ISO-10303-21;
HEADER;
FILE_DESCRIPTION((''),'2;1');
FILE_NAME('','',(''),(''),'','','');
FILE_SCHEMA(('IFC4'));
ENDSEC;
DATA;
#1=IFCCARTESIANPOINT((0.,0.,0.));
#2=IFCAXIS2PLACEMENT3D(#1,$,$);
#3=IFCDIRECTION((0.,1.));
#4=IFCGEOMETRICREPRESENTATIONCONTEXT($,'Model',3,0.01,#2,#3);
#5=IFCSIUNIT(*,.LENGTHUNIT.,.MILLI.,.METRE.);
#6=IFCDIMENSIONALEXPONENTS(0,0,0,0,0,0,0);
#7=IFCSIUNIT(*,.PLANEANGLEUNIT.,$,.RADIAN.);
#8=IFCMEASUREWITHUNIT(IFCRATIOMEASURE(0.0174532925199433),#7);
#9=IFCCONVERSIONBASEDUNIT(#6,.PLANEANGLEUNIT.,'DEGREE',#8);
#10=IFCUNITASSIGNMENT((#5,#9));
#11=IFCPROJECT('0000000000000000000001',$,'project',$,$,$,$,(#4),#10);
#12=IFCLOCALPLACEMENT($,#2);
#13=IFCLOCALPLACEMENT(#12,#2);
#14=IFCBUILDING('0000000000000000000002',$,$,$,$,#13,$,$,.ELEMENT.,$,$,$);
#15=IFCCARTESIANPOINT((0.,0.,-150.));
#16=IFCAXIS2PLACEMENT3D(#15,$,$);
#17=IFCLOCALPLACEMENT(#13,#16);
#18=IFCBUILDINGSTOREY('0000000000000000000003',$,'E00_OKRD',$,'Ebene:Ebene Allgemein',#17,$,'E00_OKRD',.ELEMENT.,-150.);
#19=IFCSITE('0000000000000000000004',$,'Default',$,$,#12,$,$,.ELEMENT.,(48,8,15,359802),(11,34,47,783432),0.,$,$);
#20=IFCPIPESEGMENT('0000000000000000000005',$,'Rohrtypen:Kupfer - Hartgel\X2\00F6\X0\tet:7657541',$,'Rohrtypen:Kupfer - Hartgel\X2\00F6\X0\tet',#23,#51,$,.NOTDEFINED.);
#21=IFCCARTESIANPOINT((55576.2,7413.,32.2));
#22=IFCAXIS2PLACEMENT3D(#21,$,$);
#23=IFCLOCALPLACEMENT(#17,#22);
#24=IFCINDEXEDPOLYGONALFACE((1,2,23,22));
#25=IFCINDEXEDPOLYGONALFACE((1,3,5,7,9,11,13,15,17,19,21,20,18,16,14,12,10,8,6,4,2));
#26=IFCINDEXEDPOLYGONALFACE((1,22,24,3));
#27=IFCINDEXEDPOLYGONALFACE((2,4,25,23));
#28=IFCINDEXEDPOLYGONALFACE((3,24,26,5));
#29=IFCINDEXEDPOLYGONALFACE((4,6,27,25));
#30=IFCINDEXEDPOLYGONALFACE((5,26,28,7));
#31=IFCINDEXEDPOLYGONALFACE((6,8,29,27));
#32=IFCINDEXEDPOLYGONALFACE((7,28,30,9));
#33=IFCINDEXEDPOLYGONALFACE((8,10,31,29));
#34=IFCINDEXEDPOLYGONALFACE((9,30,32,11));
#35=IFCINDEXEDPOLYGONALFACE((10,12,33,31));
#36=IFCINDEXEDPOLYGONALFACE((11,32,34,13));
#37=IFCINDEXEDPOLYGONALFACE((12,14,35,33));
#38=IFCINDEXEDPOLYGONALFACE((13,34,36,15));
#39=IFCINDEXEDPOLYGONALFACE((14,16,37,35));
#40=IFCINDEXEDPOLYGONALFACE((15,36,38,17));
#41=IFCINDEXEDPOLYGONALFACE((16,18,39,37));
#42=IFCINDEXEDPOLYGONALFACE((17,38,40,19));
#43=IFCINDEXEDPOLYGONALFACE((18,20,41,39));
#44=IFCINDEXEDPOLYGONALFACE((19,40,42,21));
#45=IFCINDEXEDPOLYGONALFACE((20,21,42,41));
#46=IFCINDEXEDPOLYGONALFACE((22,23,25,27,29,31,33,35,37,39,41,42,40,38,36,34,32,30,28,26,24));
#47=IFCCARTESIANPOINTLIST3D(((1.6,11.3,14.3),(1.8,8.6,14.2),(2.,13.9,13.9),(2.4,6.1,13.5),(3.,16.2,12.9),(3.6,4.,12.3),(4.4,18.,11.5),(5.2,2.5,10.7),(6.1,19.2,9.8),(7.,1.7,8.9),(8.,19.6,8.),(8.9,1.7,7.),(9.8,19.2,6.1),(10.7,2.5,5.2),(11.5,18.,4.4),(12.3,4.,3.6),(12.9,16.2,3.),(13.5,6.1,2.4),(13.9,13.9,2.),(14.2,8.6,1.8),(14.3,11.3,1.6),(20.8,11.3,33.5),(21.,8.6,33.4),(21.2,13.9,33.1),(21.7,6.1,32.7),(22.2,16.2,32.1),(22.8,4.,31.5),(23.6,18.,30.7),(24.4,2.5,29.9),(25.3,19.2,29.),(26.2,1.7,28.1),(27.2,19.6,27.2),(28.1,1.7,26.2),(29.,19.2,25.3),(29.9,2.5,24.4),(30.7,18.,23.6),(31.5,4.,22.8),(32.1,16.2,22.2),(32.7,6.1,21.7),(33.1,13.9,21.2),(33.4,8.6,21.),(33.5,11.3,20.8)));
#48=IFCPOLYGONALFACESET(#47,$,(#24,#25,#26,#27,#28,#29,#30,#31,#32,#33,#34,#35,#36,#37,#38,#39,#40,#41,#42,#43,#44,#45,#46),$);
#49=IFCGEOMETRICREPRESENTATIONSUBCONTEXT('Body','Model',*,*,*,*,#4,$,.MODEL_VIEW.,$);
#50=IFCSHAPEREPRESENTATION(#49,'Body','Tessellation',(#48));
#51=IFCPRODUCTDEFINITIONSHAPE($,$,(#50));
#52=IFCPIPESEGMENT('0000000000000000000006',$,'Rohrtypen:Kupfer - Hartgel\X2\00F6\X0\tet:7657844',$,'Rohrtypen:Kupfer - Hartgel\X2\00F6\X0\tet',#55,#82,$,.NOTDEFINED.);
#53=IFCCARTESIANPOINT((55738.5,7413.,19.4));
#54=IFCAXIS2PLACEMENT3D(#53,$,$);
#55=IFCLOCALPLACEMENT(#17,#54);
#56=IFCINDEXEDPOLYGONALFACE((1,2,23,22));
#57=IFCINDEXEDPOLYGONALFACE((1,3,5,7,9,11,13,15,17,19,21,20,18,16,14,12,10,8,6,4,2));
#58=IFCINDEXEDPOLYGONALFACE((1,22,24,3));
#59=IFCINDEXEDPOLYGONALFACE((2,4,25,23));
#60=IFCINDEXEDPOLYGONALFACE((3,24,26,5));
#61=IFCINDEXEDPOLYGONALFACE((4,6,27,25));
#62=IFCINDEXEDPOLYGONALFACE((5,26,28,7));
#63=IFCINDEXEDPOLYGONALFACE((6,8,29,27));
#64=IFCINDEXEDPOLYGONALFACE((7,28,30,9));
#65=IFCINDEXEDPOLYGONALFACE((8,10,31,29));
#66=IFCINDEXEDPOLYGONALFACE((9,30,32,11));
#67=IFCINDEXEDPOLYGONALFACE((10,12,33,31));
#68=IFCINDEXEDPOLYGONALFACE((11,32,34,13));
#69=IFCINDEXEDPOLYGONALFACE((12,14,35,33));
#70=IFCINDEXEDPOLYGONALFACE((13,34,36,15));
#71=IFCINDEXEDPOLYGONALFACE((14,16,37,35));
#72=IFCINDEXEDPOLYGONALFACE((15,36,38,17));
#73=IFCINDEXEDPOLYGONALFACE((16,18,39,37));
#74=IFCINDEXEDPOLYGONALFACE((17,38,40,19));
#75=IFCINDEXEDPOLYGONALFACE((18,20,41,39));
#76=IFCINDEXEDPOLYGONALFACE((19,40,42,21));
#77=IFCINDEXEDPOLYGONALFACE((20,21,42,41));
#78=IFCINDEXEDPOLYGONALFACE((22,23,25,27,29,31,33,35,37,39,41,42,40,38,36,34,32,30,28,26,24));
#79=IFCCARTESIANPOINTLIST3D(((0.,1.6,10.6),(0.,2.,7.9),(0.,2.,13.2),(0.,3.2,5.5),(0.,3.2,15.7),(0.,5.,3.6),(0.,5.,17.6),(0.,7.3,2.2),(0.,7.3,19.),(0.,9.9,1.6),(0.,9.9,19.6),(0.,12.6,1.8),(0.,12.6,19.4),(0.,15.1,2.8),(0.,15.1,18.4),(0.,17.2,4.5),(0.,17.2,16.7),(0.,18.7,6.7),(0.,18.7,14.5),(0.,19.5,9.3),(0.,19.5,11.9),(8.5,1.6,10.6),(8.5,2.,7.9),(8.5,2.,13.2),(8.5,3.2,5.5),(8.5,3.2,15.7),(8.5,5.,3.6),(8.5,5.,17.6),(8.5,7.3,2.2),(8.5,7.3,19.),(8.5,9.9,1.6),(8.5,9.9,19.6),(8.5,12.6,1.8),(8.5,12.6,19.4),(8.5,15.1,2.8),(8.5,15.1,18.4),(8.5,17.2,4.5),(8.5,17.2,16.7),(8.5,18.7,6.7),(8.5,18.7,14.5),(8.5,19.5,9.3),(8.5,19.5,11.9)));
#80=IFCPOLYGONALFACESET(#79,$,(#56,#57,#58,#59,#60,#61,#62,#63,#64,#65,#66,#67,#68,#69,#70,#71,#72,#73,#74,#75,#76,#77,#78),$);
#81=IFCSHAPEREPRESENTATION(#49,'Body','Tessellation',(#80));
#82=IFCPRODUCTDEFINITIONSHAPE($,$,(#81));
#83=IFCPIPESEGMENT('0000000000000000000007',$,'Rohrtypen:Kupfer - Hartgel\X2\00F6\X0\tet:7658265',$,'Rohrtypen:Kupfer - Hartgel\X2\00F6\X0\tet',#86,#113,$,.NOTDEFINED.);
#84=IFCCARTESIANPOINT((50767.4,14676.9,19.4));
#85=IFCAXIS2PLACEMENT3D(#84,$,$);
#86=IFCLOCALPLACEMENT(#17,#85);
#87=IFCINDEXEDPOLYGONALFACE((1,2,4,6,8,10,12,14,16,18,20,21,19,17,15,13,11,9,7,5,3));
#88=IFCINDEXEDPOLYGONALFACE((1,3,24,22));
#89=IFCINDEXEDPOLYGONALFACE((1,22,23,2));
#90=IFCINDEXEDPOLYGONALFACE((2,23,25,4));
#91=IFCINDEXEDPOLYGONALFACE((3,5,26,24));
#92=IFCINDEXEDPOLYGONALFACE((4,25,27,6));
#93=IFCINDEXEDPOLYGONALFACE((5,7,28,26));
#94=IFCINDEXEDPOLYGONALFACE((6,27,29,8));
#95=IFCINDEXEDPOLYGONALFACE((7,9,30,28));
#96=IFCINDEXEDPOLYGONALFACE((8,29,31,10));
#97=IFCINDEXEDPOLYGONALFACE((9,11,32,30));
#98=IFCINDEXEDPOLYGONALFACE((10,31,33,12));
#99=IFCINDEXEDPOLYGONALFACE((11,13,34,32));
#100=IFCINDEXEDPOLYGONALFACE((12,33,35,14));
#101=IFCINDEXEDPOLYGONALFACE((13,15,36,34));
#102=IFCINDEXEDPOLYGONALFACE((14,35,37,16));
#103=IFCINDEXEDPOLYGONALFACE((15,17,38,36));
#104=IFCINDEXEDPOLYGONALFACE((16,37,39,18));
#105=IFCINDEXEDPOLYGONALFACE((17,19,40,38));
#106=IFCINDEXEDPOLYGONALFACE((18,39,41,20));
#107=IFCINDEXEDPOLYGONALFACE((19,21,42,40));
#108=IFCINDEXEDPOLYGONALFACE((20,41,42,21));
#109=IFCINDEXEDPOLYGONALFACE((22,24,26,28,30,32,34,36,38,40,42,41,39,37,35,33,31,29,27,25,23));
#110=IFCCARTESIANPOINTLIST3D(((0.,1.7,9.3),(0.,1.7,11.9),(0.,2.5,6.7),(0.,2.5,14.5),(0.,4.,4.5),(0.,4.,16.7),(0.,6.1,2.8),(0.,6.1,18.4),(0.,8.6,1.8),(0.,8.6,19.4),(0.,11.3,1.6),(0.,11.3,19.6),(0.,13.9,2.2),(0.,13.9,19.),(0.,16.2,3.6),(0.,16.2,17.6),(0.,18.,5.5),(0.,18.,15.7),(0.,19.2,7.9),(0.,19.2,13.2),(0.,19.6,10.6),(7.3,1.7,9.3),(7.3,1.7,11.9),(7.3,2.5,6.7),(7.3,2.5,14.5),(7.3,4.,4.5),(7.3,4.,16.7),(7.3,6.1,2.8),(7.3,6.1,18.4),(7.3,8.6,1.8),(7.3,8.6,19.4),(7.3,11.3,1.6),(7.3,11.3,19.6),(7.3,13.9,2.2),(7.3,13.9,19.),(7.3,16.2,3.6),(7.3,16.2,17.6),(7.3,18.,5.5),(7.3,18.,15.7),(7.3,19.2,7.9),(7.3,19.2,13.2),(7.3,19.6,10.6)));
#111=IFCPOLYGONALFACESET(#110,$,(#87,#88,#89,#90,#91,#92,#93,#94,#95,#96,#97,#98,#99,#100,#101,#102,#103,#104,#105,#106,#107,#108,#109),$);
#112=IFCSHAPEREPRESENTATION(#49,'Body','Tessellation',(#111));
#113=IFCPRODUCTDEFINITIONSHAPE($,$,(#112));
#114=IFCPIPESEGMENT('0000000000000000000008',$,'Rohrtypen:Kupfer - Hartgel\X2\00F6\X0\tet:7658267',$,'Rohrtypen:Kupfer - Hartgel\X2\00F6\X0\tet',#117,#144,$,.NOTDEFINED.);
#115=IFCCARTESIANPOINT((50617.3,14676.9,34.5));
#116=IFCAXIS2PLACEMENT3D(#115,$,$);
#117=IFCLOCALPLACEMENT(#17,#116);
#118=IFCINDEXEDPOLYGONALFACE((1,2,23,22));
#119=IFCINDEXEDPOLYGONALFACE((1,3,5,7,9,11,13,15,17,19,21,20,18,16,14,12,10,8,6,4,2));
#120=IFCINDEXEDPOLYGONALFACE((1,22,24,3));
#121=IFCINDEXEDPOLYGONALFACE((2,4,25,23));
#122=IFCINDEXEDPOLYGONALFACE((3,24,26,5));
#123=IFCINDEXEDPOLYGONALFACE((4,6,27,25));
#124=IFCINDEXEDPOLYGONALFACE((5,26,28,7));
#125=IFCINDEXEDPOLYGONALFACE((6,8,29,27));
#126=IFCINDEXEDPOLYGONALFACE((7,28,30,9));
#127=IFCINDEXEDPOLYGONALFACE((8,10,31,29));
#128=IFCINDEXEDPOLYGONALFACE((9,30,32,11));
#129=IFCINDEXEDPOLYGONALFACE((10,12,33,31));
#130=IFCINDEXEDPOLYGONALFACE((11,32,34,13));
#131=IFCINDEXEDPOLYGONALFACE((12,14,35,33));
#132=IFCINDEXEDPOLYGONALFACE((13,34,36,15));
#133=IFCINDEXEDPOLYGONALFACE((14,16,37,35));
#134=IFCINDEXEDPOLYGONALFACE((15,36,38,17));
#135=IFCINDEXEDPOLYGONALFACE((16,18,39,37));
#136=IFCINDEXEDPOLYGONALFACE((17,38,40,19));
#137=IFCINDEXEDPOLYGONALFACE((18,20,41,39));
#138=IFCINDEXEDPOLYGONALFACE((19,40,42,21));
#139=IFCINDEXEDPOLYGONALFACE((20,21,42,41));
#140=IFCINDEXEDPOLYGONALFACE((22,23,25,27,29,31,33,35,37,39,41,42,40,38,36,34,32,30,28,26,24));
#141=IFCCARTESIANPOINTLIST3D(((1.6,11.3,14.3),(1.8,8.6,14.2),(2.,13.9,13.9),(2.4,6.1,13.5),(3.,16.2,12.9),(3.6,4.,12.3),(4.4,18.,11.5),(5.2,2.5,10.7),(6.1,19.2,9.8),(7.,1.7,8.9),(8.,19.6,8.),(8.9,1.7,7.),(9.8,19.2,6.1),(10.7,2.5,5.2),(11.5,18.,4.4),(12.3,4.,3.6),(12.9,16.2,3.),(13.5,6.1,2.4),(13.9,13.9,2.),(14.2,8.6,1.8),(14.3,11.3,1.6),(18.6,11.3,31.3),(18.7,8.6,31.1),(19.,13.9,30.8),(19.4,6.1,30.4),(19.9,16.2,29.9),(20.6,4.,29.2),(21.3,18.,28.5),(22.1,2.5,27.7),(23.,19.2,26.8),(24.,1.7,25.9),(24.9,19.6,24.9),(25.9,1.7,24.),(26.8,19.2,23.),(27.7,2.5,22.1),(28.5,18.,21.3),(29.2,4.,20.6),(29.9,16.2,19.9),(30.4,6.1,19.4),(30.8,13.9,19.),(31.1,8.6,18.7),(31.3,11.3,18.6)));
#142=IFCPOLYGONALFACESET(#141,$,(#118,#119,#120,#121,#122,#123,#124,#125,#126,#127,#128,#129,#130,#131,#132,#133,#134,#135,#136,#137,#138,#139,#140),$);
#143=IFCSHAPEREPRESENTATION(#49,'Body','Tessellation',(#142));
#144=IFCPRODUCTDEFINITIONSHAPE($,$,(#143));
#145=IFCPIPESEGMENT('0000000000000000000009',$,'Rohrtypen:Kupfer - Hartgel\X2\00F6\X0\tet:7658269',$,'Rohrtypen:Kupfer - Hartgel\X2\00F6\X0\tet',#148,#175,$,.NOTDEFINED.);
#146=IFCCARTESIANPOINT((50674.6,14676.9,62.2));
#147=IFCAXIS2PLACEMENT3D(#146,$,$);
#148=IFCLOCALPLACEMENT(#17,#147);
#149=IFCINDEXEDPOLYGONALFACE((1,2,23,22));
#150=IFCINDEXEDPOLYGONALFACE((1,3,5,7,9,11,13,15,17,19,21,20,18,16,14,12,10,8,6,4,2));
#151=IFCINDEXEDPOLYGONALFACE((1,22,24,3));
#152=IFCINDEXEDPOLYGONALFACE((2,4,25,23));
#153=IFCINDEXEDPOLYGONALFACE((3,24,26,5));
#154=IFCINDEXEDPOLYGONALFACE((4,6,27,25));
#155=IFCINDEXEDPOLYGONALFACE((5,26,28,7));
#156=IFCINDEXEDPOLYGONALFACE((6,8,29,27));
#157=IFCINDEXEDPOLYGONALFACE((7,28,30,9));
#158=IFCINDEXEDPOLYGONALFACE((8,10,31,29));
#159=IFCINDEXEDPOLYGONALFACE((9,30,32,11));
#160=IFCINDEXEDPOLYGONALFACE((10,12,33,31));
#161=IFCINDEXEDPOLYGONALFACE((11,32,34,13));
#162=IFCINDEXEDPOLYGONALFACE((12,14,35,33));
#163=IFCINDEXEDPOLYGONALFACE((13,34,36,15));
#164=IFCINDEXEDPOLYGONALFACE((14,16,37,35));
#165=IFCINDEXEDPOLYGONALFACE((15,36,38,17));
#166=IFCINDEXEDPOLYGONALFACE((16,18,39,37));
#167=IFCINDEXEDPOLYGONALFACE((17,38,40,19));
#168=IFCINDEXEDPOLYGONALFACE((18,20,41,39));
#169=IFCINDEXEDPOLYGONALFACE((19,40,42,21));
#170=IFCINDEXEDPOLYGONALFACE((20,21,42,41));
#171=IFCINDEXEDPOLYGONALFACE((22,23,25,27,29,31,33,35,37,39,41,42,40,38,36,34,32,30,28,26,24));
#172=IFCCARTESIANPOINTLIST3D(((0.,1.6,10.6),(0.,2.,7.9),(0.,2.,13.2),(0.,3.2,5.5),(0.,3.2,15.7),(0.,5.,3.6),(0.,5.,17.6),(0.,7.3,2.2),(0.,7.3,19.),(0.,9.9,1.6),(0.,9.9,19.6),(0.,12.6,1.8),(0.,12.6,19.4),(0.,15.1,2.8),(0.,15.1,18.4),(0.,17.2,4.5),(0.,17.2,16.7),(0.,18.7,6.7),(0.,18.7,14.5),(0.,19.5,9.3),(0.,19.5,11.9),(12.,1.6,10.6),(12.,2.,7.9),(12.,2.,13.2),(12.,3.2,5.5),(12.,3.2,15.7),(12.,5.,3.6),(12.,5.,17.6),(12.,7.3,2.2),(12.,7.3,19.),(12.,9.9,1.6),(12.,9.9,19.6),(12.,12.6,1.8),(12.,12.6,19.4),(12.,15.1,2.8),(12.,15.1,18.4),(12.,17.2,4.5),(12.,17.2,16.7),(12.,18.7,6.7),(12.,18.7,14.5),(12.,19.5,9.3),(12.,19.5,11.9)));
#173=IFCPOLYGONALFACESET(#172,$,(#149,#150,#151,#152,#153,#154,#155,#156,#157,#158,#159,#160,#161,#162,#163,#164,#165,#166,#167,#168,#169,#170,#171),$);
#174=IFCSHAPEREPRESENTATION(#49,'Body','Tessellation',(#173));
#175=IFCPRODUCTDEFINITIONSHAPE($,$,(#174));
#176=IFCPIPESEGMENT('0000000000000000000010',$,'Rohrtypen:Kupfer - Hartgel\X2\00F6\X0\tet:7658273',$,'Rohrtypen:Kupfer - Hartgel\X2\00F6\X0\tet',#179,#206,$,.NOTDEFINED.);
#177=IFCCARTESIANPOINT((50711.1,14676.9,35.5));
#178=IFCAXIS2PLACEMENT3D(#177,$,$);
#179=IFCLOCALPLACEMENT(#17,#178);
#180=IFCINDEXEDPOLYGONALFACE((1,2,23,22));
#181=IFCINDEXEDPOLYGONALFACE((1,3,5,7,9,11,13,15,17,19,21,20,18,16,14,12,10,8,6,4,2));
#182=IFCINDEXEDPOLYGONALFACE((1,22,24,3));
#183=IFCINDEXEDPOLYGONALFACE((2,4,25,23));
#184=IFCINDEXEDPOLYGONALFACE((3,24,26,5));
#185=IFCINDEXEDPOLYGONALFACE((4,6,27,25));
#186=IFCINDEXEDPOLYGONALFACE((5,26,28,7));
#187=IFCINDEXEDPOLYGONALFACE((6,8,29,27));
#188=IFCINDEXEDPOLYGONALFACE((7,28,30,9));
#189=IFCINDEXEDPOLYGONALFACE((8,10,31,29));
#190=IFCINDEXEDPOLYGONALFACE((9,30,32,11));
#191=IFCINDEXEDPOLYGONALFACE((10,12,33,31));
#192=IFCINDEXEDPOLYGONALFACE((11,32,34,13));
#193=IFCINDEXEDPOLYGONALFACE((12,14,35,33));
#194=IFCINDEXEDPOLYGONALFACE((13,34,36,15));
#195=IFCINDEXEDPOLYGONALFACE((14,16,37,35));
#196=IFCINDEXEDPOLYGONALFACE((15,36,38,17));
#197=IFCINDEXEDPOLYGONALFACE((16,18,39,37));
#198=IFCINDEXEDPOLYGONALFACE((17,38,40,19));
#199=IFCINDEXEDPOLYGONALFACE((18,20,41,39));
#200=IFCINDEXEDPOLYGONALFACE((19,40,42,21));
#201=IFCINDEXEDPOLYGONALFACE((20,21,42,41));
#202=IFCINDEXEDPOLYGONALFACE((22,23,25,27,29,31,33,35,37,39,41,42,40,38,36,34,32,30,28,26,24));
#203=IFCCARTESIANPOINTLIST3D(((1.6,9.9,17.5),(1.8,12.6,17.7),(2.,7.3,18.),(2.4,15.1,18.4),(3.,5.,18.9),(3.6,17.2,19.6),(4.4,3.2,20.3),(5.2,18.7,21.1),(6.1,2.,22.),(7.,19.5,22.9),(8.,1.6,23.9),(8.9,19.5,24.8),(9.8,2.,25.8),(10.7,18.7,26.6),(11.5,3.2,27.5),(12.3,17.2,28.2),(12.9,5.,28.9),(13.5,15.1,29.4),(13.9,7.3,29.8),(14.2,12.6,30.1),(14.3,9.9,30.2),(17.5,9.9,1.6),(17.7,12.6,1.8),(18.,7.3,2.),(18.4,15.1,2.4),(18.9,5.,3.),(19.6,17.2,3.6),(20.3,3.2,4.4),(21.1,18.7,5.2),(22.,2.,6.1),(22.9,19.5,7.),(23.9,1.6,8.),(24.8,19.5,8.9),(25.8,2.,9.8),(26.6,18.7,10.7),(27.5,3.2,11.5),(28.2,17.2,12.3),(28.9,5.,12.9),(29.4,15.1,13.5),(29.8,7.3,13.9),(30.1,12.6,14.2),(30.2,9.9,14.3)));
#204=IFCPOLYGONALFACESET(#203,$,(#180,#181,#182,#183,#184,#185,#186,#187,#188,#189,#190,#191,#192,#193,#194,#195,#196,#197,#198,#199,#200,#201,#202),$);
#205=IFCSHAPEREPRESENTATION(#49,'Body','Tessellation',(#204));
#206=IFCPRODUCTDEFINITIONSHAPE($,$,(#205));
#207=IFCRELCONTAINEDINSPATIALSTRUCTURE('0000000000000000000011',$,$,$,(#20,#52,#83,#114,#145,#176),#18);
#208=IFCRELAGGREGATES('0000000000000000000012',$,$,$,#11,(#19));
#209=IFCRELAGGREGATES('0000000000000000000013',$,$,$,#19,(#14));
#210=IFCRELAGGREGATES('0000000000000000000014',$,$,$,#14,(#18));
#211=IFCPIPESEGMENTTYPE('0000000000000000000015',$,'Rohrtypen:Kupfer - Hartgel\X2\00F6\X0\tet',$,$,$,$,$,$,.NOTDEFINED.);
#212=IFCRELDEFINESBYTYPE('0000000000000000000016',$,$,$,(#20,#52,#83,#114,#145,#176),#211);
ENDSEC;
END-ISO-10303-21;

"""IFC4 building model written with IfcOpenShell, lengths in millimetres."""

from ifc_helpers import new_model, entity, si_unit, converted_unit, direction, frame, frame_2d, origin, origin_2d_with_axis, place, context, subcontext, project, spatial, circle, extrude, type_object, element, save


model = new_model("IFC4")

# Units and contexts
model_context = context("Model", 3, precision=0.01, world=origin(), true_north=direction((0.0, 1.0)))
body_context = subcontext(model_context, "Body", "Model", "MODEL_VIEW")
ifc_project = project(units=[si_unit("LENGTHUNIT", "METRE", prefix="MILLI"), converted_unit("PLANEANGLEUNIT", "DEGREE", entity("IfcRatioMeasure", 0.0174532925199433), si_unit("PLANEANGLEUNIT", "RADIAN"), dimensions=[0, 0, 0, 0, 0, 0, 0])], contexts=[model_context])

# Site, building, storey
site_placement = place(None, origin())
site = spatial("IfcSite", under=ifc_project, at=site_placement, Name="Default", CompositionType="ELEMENT", RefLatitude=(48, 8, 15, 359802), RefLongitude=(11, 34, 47, 783432), RefElevation=0.0)
building_placement = place(site_placement, origin())
building = spatial("IfcBuilding", under=site, at=building_placement, CompositionType="ELEMENT")
storey_placement = place(building_placement, frame((0.0, 0.0, -150.0)))
storey = spatial("IfcBuildingStorey", under=building, at=storey_placement, Name="E00_OKRD", ObjectType="Ebene:Ebene Allgemein", LongName="E00_OKRD", CompositionType="ELEMENT", Elevation=-150.0)

# Pipe segments
pipe_segment_type = type_object("IfcPipeSegmentType", Name="Rohrtypen:Kupfer - Hartgelötet", PredefinedType="NOTDEFINED")
pipe_segment_1_placement = place(storey_placement, frame((55576.2, 7413.0, 32.2)))
element("IfcPipeSegment", 1, at=pipe_segment_1_placement, inside=storey, type_object=pipe_segment_type, Name="Rohrtypen:Kupfer - Hartgelötet:7657541", ObjectType="Rohrtypen:Kupfer - Hartgelötet", PredefinedType="NOTDEFINED", context=body_context, shape_type="SweptSolid", body=[
    extrude(circle(Radius=9.0, at=origin_2d_with_axis()), frame((8.0, 10.6, 8.0), z_axis=(0.707107, 0.0, 0.707107), x_axis=(0.0, 1.0, 0.0)), (0.0, 0.0, 1.0), 27.2),
])
pipe_segment_2_placement = place(storey_placement, frame((55738.5, 7413.0, 19.4)))
element("IfcPipeSegment", 2, at=pipe_segment_2_placement, inside=storey, type_object=pipe_segment_type, Name="Rohrtypen:Kupfer - Hartgelötet:7657844", ObjectType="Rohrtypen:Kupfer - Hartgelötet", PredefinedType="NOTDEFINED", context=body_context, shape_type="SweptSolid", body=[
    extrude(circle(Radius=9.0, at=frame_2d((0.0, 0.0), x_axis=(1.0, 0.0))), frame((0.0, 10.6, 10.6), z_axis=(1.0, 0.0, 0.0), x_axis=(0.0, -1.0, 0.0)), (0.0, 0.0, 1.0), 8.5),
])
pipe_segment_3_placement = place(storey_placement, frame((50767.4, 14676.9, 19.4)))
element("IfcPipeSegment", 3, at=pipe_segment_3_placement, inside=storey, type_object=pipe_segment_type, Name="Rohrtypen:Kupfer - Hartgelötet:7658265", ObjectType="Rohrtypen:Kupfer - Hartgelötet", PredefinedType="NOTDEFINED", context=body_context, shape_type="SweptSolid", body=[
    extrude(circle(Radius=9.0, at=frame_2d((0.0, 0.0), x_axis=(1.0, 0.0))), frame((0.0, 10.6, 10.6), z_axis=(1.0, 0.0, 0.0), x_axis=(0.0, 1.0, 0.0)), (0.0, 0.0, 1.0), 7.3),
])
pipe_segment_4_placement = place(storey_placement, frame((50617.3, 14676.9, 34.5)))
element("IfcPipeSegment", 4, at=pipe_segment_4_placement, inside=storey, type_object=pipe_segment_type, Name="Rohrtypen:Kupfer - Hartgelötet:7658267", ObjectType="Rohrtypen:Kupfer - Hartgelötet", PredefinedType="NOTDEFINED", context=body_context, shape_type="SweptSolid", body=[
    extrude(circle(Radius=9.0, at=origin_2d_with_axis()), frame((8.0, 10.6, 8.0), z_axis=(0.707107, 0.0, 0.707107), x_axis=(0.0, 1.0, 0.0)), (0.0, 0.0, 1.0), 24.0),
])
pipe_segment_5_placement = place(storey_placement, frame((50674.6, 14676.9, 62.2)))
element("IfcPipeSegment", 5, at=pipe_segment_5_placement, inside=storey, type_object=pipe_segment_type, Name="Rohrtypen:Kupfer - Hartgelötet:7658269", ObjectType="Rohrtypen:Kupfer - Hartgelötet", PredefinedType="NOTDEFINED", context=body_context, shape_type="SweptSolid", body=[
    extrude(circle(Radius=9.0, at=origin_2d_with_axis()), frame((0.0, 10.6, 10.6), z_axis=(1.0, 0.0, 0.0), x_axis=(0.0, -1.0, 0.0)), (0.0, 0.0, 1.0), 12.0),
])
pipe_segment_6_placement = place(storey_placement, frame((50711.1, 14676.9, 35.5)))
element("IfcPipeSegment", 6, at=pipe_segment_6_placement, inside=storey, type_object=pipe_segment_type, Name="Rohrtypen:Kupfer - Hartgelötet:7658273", ObjectType="Rohrtypen:Kupfer - Hartgelötet", PredefinedType="NOTDEFINED", context=body_context, shape_type="SweptSolid", body=[
    extrude(circle(Radius=9.0, at=frame_2d((0.0, 0.0), x_axis=(1.0, 0.0))), frame((8.0, 10.6, 23.9), z_axis=(0.707107, 0.0, -0.707107), x_axis=(0.0, -1.0, 0.0)), (0.0, 0.0, 1.0), 22.5),
])

save(model, "model.ifc")
